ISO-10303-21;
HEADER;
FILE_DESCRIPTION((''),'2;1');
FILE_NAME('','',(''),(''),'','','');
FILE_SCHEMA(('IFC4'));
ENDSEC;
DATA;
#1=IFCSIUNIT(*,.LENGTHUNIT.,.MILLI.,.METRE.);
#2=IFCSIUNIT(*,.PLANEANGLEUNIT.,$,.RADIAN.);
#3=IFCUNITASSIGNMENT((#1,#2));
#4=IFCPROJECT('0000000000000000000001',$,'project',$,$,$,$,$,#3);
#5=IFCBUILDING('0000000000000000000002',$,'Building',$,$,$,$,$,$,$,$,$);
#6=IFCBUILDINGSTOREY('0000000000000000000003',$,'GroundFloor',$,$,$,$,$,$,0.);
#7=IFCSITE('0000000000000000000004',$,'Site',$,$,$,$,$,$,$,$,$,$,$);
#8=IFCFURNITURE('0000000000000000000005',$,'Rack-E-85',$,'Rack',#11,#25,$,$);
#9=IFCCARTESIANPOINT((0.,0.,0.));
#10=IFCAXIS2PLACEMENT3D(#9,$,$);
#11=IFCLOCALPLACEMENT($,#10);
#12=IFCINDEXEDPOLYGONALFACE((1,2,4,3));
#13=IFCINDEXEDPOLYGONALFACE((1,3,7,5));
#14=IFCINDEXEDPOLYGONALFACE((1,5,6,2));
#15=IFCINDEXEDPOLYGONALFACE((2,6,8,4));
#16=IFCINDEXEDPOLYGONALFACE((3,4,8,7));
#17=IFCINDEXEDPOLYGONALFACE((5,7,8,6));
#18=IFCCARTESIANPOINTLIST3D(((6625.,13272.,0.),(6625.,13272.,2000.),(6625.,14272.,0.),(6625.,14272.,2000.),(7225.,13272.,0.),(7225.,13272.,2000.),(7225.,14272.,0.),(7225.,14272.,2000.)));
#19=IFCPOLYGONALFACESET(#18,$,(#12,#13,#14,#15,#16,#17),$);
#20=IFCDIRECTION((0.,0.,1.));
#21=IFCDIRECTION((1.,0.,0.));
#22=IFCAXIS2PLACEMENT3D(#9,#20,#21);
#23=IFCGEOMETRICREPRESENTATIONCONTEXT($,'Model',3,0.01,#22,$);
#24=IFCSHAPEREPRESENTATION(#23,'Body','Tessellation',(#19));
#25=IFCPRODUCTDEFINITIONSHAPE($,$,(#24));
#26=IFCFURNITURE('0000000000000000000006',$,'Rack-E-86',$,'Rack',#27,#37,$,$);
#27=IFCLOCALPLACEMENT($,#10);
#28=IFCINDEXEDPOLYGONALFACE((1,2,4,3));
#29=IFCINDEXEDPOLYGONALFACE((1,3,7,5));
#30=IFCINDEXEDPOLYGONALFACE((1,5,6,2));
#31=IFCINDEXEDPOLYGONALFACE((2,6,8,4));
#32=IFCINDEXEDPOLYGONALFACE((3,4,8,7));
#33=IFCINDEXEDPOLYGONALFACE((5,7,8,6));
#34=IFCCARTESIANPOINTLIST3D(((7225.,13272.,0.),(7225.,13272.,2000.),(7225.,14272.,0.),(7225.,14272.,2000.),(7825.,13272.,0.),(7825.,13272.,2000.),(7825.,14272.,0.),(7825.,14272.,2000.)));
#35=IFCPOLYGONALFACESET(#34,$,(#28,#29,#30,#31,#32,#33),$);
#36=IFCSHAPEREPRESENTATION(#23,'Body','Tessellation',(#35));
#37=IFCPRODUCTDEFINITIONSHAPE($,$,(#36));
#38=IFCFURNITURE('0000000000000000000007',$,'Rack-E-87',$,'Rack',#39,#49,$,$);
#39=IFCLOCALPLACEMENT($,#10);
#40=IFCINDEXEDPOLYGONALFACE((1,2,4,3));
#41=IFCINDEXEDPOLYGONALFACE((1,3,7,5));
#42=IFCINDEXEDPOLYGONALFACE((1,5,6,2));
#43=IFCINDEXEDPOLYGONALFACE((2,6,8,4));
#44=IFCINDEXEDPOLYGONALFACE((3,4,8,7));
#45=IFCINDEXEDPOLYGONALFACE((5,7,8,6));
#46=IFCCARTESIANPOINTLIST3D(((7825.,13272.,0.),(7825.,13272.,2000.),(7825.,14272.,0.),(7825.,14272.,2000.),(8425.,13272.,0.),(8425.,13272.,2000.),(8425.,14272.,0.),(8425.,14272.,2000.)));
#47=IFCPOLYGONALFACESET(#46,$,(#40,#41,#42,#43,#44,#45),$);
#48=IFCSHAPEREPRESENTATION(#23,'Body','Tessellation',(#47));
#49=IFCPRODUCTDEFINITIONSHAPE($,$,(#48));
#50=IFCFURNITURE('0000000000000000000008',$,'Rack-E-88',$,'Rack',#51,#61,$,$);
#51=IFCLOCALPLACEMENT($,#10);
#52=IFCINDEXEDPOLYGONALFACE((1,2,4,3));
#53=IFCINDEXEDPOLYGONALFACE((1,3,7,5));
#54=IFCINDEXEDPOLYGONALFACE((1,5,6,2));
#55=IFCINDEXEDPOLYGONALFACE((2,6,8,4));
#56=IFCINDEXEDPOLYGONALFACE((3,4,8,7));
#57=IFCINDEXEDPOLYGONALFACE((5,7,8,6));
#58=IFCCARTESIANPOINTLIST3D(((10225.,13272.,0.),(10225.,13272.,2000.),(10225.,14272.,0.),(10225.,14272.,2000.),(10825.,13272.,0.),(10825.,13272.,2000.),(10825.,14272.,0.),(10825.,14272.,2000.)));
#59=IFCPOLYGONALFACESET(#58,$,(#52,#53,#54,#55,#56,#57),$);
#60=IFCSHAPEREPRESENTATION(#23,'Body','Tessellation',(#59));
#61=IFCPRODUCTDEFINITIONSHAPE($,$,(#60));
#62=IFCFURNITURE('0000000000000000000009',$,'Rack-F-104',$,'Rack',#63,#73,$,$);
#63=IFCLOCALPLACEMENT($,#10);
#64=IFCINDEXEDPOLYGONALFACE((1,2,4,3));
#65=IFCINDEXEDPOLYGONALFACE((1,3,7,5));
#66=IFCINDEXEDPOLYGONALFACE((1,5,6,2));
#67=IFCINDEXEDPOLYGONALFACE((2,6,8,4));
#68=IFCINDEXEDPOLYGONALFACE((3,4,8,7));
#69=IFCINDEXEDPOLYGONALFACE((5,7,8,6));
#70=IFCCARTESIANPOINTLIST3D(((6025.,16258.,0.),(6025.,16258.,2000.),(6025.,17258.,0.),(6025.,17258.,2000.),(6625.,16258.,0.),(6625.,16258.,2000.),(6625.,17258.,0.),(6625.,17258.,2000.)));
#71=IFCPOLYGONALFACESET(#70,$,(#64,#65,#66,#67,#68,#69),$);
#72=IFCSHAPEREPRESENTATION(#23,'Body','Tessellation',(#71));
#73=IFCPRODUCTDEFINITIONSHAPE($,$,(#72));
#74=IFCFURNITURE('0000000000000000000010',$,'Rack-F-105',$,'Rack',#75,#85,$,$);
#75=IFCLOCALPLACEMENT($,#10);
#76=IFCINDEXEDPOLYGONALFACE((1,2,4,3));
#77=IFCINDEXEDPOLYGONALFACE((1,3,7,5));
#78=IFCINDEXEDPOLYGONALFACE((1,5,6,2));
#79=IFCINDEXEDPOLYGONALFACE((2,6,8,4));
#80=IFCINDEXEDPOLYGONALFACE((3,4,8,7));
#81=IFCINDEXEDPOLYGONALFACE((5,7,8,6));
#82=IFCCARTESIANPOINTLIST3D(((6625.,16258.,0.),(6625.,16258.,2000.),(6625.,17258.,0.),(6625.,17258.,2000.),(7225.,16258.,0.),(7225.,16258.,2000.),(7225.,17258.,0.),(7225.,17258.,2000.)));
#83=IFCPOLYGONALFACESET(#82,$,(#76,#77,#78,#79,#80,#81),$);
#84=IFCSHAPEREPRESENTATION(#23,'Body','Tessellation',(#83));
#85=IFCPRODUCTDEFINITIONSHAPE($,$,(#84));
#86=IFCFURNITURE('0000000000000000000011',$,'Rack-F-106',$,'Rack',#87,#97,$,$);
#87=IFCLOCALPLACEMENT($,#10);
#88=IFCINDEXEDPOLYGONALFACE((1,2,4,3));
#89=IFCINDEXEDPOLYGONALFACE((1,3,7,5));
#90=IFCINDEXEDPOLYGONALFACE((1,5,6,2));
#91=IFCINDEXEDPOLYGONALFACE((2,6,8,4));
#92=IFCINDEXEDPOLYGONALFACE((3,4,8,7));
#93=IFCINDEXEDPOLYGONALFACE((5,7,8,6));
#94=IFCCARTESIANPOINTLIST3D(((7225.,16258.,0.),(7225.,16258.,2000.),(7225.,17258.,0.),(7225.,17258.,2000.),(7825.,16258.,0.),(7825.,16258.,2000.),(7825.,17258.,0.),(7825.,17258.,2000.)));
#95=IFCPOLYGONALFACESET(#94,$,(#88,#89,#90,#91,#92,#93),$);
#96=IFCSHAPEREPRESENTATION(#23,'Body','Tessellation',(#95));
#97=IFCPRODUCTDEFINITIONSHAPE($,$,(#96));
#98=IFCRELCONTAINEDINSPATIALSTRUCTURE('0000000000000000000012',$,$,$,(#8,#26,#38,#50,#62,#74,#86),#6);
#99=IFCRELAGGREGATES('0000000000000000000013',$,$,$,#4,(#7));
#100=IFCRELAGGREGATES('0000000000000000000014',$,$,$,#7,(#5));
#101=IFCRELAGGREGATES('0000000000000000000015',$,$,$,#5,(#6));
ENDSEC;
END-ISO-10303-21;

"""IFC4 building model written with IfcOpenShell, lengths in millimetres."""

from ifc_helpers import new_model, si_unit, frame, origin, origin_with_axes, origin_2d, place, context, project, spatial, rectangle, extrude, element, save


model = new_model("IFC4")

# Units and contexts
model_context = context("Model", 3, precision=0.01, world=origin_with_axes())
ifc_project = project(units=[si_unit("LENGTHUNIT", "METRE", prefix="MILLI"), si_unit("PLANEANGLEUNIT", "RADIAN")])

# Site, building, storey
site = spatial("IfcSite", under=ifc_project, Name="Site")
building = spatial("IfcBuilding", under=site, Name="Building")
storey = spatial("IfcBuildingStorey", under=building, Name="GroundFloor", Elevation=0.0)

# Furniture
for number, where, z_axis, x_axis, name in (
    (1, (6925.0, 13772.0, 0.0), (0.0, 0.0, 1.0), (1.0, 0.0, 0.0), "Rack-E-85"),
    (2, (7525.0, 13772.0, 0.0), (0.0, 0.0, 1.0), (1.0, 0.0, 0.0), "Rack-E-86"),
    (3, (8125.0, 13772.0, 0.0), (0.0, 0.0, 1.0), (1.0, 0.0, 0.0), "Rack-E-87"),
    (4, (10525.0, 13772.0, 0.0), (0.0, 0.0, 1.0), (1.0, 0.0, 0.0), "Rack-E-88"),
    (5, (6325.0, 16758.0, 0.0), (0.0, 0.0, 1.0), (1.0, 0.0, 0.0), "Rack-F-104"),
    (6, (6925.0, 16758.0, 0.0), (0.0, 0.0, 1.0), (1.0, 0.0, 0.0), "Rack-F-105"),
    (7, (7525.0, 16758.0, 0.0), (0.0, 0.0, 1.0), (1.0, 0.0, 0.0), "Rack-F-106"),
):
    element("IfcFurniture", number, at=place(None, frame(where, z_axis=z_axis, x_axis=x_axis)), inside=storey, Name=name, ObjectType="Rack", context=model_context, shape_type="SweptSolid", body=[
        extrude(rectangle(XDim=600.0, YDim=1000.0, at=origin_2d()), origin(), (0.0, 0.0, 1.0), 2000.0),
    ])

save(model, "model.ifc")
